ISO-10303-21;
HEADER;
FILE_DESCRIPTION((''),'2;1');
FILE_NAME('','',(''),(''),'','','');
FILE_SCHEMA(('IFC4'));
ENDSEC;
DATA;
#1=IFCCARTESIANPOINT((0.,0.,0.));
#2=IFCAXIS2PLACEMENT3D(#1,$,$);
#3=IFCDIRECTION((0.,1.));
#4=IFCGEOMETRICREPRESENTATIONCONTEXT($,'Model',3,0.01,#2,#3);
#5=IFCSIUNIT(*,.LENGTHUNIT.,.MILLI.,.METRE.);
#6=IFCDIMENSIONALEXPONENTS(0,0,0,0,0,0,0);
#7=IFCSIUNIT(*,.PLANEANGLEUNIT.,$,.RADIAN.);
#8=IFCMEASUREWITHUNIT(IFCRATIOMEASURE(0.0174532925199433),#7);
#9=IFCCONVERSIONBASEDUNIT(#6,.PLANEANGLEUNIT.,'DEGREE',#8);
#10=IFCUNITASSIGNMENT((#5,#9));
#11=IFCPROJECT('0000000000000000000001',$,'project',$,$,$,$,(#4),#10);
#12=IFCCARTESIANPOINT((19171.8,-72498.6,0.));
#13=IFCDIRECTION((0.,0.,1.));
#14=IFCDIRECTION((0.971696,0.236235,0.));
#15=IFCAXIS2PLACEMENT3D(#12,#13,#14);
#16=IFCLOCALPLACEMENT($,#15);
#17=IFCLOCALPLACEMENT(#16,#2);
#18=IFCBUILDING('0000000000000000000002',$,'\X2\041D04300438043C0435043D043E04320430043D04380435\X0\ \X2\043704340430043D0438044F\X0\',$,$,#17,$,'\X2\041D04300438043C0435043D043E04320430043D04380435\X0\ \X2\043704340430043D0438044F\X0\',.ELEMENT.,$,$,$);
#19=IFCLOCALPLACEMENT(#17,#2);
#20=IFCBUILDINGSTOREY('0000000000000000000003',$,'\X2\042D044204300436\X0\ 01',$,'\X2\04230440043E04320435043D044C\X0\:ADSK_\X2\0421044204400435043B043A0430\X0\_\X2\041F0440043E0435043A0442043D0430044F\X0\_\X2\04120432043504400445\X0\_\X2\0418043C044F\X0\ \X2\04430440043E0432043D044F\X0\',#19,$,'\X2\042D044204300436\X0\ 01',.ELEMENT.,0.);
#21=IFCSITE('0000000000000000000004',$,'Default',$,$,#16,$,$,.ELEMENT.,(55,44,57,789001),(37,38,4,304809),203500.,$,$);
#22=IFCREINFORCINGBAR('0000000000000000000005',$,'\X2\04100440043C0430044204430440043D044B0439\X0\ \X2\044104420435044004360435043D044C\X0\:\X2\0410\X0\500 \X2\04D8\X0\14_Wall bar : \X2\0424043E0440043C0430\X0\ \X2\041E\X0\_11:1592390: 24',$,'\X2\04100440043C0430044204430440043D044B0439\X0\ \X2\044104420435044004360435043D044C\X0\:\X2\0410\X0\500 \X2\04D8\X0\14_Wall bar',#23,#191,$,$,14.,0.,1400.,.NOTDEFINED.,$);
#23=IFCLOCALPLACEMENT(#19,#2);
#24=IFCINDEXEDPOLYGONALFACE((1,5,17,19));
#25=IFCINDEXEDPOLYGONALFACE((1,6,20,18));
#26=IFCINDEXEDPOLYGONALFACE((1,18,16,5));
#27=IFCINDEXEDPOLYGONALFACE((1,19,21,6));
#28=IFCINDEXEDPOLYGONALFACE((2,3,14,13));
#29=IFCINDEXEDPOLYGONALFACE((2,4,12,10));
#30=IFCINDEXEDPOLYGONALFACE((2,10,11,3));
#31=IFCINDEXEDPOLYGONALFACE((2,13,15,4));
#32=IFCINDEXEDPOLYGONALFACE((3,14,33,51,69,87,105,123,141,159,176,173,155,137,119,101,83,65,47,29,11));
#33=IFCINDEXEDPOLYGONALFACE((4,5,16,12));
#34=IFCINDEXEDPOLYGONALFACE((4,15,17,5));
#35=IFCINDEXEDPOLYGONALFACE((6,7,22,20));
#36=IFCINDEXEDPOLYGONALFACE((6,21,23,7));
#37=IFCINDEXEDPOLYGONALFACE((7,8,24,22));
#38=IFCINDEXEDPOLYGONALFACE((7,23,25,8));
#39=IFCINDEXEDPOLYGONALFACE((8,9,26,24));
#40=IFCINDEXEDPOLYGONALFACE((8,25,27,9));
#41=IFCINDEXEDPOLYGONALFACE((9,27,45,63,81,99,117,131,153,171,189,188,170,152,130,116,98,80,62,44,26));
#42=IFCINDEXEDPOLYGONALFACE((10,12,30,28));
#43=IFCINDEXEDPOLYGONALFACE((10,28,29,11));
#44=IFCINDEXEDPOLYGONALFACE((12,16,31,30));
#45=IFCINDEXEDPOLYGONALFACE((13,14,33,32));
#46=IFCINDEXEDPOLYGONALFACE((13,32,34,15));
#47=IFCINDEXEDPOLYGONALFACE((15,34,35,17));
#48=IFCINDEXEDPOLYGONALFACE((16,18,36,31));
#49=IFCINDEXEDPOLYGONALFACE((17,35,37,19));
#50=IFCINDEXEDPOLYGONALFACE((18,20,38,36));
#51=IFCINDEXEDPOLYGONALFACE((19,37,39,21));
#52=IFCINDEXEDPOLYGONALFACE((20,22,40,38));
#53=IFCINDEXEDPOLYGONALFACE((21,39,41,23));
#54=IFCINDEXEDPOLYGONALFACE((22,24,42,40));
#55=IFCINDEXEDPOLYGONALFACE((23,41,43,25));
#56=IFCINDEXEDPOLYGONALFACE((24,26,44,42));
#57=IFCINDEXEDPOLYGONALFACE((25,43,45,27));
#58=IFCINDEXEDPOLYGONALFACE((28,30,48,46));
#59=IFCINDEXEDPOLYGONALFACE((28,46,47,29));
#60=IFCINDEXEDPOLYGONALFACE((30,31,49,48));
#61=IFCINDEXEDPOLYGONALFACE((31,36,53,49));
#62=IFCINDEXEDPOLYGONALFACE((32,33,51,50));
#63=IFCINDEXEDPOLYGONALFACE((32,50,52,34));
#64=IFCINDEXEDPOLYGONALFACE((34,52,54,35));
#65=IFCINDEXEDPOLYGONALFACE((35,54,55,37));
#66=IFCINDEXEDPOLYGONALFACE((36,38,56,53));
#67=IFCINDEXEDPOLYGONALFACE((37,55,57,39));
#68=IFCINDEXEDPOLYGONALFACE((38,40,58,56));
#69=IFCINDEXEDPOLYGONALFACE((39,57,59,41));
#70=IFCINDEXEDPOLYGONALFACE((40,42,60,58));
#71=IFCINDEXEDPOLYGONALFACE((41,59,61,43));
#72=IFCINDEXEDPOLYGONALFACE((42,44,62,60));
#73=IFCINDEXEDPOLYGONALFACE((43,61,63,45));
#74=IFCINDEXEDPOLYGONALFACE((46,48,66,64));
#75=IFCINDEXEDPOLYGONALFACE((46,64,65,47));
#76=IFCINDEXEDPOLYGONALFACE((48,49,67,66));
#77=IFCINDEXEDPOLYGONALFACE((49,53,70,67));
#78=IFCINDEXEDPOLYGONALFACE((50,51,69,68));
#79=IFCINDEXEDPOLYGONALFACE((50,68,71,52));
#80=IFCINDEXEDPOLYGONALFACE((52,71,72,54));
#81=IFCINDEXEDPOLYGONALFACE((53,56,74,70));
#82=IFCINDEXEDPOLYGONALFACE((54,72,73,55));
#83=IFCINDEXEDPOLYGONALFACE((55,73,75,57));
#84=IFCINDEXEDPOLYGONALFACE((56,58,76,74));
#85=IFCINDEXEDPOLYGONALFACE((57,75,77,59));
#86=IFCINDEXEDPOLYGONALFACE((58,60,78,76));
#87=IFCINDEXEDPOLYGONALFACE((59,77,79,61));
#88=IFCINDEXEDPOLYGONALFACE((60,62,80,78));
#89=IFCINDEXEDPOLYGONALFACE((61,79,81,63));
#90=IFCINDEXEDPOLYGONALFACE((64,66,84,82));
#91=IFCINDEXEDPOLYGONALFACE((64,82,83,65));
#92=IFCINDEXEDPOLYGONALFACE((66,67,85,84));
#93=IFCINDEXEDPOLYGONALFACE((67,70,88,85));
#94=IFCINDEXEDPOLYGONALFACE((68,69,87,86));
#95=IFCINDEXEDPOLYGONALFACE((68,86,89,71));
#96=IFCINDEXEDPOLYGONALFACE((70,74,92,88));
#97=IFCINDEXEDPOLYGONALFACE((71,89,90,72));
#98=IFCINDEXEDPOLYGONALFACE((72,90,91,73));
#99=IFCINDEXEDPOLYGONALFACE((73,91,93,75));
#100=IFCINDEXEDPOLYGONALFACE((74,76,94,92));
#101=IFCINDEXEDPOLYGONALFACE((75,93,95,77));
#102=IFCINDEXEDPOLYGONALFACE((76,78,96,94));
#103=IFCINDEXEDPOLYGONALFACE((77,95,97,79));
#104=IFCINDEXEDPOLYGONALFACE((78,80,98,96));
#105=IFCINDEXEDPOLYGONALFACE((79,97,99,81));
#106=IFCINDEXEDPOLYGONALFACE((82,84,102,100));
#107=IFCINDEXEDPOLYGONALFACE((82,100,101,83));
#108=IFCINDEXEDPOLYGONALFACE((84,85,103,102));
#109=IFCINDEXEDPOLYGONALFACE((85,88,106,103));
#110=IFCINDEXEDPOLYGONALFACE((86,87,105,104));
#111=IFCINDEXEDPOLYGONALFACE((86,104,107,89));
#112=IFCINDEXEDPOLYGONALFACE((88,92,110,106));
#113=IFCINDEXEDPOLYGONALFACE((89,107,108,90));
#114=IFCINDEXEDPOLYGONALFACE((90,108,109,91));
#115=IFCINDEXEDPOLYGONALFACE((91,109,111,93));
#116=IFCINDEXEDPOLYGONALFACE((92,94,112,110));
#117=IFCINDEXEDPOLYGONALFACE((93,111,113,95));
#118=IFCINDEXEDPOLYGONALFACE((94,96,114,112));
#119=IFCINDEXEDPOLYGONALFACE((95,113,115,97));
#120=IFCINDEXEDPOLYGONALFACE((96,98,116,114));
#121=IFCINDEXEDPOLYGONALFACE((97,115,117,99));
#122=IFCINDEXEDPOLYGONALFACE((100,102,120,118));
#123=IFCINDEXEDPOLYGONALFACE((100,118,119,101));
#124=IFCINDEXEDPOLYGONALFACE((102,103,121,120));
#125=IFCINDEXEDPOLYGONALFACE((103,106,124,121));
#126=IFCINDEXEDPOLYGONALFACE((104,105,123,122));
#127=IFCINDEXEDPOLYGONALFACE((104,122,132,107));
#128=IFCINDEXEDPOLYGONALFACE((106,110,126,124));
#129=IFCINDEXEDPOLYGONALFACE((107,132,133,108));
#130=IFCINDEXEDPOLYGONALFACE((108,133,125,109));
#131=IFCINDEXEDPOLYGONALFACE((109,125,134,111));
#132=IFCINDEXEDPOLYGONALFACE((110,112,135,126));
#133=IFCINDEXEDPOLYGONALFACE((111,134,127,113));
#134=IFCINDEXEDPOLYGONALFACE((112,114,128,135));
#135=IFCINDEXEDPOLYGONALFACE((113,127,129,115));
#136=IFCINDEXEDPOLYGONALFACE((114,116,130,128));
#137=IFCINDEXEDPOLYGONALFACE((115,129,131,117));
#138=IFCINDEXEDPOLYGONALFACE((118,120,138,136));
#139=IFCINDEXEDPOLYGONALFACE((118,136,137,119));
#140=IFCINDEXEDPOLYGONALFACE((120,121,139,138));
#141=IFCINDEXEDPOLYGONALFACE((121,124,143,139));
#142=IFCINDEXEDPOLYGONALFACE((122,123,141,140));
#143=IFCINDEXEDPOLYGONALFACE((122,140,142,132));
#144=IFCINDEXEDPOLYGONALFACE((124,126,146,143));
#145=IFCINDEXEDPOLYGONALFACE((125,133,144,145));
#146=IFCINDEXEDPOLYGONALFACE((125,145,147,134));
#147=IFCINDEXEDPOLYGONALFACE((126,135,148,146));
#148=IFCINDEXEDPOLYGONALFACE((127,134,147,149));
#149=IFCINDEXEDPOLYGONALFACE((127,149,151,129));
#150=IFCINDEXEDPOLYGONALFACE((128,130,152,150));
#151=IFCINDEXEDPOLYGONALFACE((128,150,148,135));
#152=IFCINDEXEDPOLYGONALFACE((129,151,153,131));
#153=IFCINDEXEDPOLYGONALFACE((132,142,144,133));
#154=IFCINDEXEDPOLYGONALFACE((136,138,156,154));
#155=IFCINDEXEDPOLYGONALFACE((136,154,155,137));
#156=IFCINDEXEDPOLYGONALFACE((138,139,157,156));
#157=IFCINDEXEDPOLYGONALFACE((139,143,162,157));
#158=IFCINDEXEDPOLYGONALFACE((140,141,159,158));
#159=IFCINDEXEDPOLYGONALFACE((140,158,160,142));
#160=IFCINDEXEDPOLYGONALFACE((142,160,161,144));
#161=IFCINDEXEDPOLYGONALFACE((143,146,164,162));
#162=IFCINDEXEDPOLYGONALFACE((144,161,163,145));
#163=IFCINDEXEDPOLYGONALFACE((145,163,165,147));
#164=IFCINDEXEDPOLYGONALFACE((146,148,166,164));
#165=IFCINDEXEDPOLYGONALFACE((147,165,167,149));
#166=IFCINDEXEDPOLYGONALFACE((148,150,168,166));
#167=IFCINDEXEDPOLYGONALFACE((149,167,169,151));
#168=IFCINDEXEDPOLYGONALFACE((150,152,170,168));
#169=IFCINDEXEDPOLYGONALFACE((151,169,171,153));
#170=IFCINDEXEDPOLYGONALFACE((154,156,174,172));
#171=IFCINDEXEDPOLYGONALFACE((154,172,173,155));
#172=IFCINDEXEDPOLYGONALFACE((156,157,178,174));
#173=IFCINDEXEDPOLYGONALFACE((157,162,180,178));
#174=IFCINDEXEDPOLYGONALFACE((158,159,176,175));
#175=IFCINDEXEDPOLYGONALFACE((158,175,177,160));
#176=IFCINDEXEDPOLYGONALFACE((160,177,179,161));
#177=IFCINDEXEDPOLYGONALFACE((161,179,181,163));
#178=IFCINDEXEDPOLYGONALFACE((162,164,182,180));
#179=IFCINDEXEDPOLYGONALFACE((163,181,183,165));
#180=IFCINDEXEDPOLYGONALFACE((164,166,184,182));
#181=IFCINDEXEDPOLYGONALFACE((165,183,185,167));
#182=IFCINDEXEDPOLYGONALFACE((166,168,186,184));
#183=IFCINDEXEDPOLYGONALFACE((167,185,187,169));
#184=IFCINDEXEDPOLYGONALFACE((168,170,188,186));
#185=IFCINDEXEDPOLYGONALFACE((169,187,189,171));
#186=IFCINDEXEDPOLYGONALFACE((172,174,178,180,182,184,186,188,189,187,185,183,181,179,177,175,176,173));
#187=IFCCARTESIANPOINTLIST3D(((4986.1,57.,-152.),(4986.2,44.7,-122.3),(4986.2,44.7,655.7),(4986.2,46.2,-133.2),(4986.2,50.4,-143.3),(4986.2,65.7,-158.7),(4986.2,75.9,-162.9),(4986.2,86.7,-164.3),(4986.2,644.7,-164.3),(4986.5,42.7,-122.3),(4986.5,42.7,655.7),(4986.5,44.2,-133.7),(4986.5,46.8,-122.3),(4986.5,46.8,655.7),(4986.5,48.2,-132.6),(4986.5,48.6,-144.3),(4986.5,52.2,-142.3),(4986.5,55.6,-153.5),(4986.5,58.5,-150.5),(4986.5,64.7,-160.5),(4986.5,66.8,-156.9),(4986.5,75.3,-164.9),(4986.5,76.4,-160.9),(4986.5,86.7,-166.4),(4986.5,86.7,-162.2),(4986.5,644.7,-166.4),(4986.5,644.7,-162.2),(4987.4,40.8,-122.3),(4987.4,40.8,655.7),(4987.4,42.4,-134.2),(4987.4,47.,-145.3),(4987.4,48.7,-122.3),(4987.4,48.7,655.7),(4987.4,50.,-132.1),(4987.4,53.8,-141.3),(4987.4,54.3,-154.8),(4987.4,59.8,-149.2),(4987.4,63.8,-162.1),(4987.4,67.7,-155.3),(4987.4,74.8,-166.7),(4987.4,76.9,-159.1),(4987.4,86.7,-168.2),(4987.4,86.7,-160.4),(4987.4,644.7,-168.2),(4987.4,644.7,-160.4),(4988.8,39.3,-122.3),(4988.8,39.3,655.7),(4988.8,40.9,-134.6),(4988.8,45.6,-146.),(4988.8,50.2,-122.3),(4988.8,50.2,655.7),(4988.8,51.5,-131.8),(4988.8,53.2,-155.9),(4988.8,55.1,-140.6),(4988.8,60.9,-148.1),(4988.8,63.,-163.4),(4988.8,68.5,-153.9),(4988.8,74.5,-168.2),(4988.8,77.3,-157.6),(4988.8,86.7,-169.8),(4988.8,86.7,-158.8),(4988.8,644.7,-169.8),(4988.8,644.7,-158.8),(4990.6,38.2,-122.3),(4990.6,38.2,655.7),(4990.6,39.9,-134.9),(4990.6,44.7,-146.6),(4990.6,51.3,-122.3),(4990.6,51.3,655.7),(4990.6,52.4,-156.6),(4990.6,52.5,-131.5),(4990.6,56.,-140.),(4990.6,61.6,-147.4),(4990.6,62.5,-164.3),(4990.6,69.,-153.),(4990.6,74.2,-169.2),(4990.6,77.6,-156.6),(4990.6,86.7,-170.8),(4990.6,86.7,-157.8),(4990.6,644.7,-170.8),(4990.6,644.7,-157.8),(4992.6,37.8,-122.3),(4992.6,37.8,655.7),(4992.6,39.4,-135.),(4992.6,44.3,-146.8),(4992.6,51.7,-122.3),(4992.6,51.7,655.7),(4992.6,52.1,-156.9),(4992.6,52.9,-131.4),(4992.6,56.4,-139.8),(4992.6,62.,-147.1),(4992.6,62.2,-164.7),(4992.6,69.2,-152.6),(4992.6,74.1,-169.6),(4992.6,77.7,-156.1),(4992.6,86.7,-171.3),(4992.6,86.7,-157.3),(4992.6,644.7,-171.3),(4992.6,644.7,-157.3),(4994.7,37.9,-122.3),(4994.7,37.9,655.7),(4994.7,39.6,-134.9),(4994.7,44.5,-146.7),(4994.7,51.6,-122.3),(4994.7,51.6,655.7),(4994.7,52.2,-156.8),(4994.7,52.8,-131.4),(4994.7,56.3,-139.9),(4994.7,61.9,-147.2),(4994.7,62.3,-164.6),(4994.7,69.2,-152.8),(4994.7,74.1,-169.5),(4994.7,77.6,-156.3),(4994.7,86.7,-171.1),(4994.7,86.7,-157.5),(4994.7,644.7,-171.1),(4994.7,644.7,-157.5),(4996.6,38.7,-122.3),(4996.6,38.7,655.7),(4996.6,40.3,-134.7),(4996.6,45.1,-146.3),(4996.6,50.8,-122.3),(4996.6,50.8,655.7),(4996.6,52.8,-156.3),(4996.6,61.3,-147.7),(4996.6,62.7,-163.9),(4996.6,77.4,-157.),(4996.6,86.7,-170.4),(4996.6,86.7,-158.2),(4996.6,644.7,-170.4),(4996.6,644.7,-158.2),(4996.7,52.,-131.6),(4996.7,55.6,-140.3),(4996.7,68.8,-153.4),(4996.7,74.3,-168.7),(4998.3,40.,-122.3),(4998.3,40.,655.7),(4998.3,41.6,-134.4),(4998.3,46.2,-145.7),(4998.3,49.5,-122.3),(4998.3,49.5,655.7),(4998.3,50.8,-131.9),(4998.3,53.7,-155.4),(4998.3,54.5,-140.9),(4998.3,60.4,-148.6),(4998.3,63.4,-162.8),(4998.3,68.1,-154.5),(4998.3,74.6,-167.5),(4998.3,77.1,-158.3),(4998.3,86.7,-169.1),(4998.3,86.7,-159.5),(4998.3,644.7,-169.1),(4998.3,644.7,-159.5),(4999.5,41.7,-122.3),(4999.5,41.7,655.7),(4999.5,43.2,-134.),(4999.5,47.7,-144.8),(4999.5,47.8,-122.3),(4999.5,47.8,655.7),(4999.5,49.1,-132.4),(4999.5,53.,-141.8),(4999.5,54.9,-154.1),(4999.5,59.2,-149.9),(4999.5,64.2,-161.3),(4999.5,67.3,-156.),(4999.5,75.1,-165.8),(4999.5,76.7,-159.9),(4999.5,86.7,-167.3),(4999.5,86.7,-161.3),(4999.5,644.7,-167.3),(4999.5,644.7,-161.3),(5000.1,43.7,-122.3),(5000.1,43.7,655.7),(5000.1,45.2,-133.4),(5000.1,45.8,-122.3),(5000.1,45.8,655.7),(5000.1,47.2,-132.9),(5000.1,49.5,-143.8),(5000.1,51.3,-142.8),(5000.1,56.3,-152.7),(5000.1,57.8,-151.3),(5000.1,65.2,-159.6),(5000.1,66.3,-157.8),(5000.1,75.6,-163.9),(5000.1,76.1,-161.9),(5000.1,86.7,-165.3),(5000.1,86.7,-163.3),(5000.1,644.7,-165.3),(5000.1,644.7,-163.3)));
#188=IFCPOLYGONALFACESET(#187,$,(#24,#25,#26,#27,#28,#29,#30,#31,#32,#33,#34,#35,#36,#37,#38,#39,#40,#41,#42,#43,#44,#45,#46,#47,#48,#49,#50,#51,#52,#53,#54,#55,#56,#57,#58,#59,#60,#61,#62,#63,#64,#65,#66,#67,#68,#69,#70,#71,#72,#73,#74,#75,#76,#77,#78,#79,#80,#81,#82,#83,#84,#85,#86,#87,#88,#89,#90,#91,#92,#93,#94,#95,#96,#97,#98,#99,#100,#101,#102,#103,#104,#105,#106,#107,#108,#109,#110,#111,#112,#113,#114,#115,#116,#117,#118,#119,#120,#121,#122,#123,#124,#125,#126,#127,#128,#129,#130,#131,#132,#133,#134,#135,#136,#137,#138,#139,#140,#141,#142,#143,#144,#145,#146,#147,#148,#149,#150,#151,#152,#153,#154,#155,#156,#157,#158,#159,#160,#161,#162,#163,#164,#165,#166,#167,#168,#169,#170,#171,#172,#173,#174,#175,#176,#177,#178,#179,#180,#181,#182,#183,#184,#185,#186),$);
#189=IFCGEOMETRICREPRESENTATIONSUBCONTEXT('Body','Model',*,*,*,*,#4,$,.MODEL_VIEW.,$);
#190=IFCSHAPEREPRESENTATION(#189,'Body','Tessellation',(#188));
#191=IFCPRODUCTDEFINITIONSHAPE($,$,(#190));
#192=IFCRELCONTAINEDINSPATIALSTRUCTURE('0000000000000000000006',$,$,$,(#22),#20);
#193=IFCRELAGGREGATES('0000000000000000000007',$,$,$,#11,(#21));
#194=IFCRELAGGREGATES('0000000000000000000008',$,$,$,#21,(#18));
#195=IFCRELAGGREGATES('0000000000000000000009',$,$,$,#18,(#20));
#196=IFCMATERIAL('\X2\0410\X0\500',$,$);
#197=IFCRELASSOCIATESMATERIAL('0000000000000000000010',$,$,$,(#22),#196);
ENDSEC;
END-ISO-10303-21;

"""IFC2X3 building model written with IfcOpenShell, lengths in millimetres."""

from ifc_helpers import new_model, entity, si_unit, converted_unit, direction, frame, origin, place, context, subcontext, project, spatial, material, element, save


model = new_model("IFC2X3")

# Units and contexts
model_context = context("Model", 3, precision=0.01, world=origin(), true_north=direction((0.0, 1.0)))
body_context = subcontext(model_context, "Body", "Model", "MODEL_VIEW")
ifc_project = project(units=[si_unit("LENGTHUNIT", "METRE", prefix="MILLI"), converted_unit("PLANEANGLEUNIT", "DEGREE", entity("IfcRatioMeasure", 0.0174532925199433), si_unit("PLANEANGLEUNIT", "RADIAN"), dimensions=[0, 0, 0, 0, 0, 0, 0])], contexts=[model_context])

# Site, building, storey
site_placement = place(None, frame((19171.8, -72498.6, 0.0), z_axis=(0.0, 0.0, 1.0), x_axis=(0.971696, 0.236235, 0.0)))
site = spatial("IfcSite", under=ifc_project, at=site_placement, Name="Default", CompositionType="ELEMENT", RefLatitude=(55, 44, 57, 789001), RefLongitude=(37, 38, 4, 304809), RefElevation=203500.0)
building_placement = place(site_placement, origin())
building = spatial("IfcBuilding", under=site, at=building_placement, Name="Наименование здания", LongName="Наименование здания", CompositionType="ELEMENT")
storey_placement = place(building_placement, origin())
storey = spatial("IfcBuildingStorey", under=building, at=storey_placement, Name="Этаж 01", ObjectType="Уровень:ADSK_Стрелка_Проектная_Вверх_Имя уровня", LongName="Этаж 01", CompositionType="ELEMENT", Elevation=0.0)

# Reinforcing bar
ifc_material = material(Name="А500")
placement = place(storey_placement, origin())
element("IfcReinforcingBar", 1, at=placement, inside=storey, material=ifc_material, Name="Арматурный стержень:А500 Ә14_Wall bar : Форма О_11:1592390: 24", ObjectType="Арматурный стержень:А500 Ә14_Wall bar", BarLength=1400.0, BarRole="NOTDEFINED", CrossSectionArea=0.0, NominalDiameter=14.0, context=body_context, shape_type="AdvancedSweptSolid", body=[
    entity("IfcSweptDiskSolid", entity("IfcCompositeCurve", [entity("IfcCompositeCurveSegment", "CONTINUOUS", True, entity("IfcPolyline", [entity("IfcCartesianPoint", [4993.1, 44.7, 655.7]), entity("IfcCartesianPoint", [4993.1, 44.7, -122.3])])), entity("IfcCompositeCurveSegment", "CONTINUOUS", True, entity("IfcTrimmedCurve", entity("IfcCircle", entity("IfcAxis2Placement3D", entity("IfcCartesianPoint", [4993.1, 86.7, -122.3]), entity("IfcDirection", [1.0, 0.0, 0.0]), entity("IfcDirection", [0.0, 0.0, -1.0])), 42.0), [entity("IfcParameterValue", 270.0)], [entity("IfcParameterValue", 360.0)], True, "PARAMETER")), entity("IfcCompositeCurveSegment", "CONTINUOUS", True, entity("IfcPolyline", [entity("IfcCartesianPoint", [4993.1, 86.7, -164.3]), entity("IfcCartesianPoint", [4993.1, 644.7, -164.3])]))], False), 7.0, None, 0.0, 92.0),
])

save(model, "model.ifc")
